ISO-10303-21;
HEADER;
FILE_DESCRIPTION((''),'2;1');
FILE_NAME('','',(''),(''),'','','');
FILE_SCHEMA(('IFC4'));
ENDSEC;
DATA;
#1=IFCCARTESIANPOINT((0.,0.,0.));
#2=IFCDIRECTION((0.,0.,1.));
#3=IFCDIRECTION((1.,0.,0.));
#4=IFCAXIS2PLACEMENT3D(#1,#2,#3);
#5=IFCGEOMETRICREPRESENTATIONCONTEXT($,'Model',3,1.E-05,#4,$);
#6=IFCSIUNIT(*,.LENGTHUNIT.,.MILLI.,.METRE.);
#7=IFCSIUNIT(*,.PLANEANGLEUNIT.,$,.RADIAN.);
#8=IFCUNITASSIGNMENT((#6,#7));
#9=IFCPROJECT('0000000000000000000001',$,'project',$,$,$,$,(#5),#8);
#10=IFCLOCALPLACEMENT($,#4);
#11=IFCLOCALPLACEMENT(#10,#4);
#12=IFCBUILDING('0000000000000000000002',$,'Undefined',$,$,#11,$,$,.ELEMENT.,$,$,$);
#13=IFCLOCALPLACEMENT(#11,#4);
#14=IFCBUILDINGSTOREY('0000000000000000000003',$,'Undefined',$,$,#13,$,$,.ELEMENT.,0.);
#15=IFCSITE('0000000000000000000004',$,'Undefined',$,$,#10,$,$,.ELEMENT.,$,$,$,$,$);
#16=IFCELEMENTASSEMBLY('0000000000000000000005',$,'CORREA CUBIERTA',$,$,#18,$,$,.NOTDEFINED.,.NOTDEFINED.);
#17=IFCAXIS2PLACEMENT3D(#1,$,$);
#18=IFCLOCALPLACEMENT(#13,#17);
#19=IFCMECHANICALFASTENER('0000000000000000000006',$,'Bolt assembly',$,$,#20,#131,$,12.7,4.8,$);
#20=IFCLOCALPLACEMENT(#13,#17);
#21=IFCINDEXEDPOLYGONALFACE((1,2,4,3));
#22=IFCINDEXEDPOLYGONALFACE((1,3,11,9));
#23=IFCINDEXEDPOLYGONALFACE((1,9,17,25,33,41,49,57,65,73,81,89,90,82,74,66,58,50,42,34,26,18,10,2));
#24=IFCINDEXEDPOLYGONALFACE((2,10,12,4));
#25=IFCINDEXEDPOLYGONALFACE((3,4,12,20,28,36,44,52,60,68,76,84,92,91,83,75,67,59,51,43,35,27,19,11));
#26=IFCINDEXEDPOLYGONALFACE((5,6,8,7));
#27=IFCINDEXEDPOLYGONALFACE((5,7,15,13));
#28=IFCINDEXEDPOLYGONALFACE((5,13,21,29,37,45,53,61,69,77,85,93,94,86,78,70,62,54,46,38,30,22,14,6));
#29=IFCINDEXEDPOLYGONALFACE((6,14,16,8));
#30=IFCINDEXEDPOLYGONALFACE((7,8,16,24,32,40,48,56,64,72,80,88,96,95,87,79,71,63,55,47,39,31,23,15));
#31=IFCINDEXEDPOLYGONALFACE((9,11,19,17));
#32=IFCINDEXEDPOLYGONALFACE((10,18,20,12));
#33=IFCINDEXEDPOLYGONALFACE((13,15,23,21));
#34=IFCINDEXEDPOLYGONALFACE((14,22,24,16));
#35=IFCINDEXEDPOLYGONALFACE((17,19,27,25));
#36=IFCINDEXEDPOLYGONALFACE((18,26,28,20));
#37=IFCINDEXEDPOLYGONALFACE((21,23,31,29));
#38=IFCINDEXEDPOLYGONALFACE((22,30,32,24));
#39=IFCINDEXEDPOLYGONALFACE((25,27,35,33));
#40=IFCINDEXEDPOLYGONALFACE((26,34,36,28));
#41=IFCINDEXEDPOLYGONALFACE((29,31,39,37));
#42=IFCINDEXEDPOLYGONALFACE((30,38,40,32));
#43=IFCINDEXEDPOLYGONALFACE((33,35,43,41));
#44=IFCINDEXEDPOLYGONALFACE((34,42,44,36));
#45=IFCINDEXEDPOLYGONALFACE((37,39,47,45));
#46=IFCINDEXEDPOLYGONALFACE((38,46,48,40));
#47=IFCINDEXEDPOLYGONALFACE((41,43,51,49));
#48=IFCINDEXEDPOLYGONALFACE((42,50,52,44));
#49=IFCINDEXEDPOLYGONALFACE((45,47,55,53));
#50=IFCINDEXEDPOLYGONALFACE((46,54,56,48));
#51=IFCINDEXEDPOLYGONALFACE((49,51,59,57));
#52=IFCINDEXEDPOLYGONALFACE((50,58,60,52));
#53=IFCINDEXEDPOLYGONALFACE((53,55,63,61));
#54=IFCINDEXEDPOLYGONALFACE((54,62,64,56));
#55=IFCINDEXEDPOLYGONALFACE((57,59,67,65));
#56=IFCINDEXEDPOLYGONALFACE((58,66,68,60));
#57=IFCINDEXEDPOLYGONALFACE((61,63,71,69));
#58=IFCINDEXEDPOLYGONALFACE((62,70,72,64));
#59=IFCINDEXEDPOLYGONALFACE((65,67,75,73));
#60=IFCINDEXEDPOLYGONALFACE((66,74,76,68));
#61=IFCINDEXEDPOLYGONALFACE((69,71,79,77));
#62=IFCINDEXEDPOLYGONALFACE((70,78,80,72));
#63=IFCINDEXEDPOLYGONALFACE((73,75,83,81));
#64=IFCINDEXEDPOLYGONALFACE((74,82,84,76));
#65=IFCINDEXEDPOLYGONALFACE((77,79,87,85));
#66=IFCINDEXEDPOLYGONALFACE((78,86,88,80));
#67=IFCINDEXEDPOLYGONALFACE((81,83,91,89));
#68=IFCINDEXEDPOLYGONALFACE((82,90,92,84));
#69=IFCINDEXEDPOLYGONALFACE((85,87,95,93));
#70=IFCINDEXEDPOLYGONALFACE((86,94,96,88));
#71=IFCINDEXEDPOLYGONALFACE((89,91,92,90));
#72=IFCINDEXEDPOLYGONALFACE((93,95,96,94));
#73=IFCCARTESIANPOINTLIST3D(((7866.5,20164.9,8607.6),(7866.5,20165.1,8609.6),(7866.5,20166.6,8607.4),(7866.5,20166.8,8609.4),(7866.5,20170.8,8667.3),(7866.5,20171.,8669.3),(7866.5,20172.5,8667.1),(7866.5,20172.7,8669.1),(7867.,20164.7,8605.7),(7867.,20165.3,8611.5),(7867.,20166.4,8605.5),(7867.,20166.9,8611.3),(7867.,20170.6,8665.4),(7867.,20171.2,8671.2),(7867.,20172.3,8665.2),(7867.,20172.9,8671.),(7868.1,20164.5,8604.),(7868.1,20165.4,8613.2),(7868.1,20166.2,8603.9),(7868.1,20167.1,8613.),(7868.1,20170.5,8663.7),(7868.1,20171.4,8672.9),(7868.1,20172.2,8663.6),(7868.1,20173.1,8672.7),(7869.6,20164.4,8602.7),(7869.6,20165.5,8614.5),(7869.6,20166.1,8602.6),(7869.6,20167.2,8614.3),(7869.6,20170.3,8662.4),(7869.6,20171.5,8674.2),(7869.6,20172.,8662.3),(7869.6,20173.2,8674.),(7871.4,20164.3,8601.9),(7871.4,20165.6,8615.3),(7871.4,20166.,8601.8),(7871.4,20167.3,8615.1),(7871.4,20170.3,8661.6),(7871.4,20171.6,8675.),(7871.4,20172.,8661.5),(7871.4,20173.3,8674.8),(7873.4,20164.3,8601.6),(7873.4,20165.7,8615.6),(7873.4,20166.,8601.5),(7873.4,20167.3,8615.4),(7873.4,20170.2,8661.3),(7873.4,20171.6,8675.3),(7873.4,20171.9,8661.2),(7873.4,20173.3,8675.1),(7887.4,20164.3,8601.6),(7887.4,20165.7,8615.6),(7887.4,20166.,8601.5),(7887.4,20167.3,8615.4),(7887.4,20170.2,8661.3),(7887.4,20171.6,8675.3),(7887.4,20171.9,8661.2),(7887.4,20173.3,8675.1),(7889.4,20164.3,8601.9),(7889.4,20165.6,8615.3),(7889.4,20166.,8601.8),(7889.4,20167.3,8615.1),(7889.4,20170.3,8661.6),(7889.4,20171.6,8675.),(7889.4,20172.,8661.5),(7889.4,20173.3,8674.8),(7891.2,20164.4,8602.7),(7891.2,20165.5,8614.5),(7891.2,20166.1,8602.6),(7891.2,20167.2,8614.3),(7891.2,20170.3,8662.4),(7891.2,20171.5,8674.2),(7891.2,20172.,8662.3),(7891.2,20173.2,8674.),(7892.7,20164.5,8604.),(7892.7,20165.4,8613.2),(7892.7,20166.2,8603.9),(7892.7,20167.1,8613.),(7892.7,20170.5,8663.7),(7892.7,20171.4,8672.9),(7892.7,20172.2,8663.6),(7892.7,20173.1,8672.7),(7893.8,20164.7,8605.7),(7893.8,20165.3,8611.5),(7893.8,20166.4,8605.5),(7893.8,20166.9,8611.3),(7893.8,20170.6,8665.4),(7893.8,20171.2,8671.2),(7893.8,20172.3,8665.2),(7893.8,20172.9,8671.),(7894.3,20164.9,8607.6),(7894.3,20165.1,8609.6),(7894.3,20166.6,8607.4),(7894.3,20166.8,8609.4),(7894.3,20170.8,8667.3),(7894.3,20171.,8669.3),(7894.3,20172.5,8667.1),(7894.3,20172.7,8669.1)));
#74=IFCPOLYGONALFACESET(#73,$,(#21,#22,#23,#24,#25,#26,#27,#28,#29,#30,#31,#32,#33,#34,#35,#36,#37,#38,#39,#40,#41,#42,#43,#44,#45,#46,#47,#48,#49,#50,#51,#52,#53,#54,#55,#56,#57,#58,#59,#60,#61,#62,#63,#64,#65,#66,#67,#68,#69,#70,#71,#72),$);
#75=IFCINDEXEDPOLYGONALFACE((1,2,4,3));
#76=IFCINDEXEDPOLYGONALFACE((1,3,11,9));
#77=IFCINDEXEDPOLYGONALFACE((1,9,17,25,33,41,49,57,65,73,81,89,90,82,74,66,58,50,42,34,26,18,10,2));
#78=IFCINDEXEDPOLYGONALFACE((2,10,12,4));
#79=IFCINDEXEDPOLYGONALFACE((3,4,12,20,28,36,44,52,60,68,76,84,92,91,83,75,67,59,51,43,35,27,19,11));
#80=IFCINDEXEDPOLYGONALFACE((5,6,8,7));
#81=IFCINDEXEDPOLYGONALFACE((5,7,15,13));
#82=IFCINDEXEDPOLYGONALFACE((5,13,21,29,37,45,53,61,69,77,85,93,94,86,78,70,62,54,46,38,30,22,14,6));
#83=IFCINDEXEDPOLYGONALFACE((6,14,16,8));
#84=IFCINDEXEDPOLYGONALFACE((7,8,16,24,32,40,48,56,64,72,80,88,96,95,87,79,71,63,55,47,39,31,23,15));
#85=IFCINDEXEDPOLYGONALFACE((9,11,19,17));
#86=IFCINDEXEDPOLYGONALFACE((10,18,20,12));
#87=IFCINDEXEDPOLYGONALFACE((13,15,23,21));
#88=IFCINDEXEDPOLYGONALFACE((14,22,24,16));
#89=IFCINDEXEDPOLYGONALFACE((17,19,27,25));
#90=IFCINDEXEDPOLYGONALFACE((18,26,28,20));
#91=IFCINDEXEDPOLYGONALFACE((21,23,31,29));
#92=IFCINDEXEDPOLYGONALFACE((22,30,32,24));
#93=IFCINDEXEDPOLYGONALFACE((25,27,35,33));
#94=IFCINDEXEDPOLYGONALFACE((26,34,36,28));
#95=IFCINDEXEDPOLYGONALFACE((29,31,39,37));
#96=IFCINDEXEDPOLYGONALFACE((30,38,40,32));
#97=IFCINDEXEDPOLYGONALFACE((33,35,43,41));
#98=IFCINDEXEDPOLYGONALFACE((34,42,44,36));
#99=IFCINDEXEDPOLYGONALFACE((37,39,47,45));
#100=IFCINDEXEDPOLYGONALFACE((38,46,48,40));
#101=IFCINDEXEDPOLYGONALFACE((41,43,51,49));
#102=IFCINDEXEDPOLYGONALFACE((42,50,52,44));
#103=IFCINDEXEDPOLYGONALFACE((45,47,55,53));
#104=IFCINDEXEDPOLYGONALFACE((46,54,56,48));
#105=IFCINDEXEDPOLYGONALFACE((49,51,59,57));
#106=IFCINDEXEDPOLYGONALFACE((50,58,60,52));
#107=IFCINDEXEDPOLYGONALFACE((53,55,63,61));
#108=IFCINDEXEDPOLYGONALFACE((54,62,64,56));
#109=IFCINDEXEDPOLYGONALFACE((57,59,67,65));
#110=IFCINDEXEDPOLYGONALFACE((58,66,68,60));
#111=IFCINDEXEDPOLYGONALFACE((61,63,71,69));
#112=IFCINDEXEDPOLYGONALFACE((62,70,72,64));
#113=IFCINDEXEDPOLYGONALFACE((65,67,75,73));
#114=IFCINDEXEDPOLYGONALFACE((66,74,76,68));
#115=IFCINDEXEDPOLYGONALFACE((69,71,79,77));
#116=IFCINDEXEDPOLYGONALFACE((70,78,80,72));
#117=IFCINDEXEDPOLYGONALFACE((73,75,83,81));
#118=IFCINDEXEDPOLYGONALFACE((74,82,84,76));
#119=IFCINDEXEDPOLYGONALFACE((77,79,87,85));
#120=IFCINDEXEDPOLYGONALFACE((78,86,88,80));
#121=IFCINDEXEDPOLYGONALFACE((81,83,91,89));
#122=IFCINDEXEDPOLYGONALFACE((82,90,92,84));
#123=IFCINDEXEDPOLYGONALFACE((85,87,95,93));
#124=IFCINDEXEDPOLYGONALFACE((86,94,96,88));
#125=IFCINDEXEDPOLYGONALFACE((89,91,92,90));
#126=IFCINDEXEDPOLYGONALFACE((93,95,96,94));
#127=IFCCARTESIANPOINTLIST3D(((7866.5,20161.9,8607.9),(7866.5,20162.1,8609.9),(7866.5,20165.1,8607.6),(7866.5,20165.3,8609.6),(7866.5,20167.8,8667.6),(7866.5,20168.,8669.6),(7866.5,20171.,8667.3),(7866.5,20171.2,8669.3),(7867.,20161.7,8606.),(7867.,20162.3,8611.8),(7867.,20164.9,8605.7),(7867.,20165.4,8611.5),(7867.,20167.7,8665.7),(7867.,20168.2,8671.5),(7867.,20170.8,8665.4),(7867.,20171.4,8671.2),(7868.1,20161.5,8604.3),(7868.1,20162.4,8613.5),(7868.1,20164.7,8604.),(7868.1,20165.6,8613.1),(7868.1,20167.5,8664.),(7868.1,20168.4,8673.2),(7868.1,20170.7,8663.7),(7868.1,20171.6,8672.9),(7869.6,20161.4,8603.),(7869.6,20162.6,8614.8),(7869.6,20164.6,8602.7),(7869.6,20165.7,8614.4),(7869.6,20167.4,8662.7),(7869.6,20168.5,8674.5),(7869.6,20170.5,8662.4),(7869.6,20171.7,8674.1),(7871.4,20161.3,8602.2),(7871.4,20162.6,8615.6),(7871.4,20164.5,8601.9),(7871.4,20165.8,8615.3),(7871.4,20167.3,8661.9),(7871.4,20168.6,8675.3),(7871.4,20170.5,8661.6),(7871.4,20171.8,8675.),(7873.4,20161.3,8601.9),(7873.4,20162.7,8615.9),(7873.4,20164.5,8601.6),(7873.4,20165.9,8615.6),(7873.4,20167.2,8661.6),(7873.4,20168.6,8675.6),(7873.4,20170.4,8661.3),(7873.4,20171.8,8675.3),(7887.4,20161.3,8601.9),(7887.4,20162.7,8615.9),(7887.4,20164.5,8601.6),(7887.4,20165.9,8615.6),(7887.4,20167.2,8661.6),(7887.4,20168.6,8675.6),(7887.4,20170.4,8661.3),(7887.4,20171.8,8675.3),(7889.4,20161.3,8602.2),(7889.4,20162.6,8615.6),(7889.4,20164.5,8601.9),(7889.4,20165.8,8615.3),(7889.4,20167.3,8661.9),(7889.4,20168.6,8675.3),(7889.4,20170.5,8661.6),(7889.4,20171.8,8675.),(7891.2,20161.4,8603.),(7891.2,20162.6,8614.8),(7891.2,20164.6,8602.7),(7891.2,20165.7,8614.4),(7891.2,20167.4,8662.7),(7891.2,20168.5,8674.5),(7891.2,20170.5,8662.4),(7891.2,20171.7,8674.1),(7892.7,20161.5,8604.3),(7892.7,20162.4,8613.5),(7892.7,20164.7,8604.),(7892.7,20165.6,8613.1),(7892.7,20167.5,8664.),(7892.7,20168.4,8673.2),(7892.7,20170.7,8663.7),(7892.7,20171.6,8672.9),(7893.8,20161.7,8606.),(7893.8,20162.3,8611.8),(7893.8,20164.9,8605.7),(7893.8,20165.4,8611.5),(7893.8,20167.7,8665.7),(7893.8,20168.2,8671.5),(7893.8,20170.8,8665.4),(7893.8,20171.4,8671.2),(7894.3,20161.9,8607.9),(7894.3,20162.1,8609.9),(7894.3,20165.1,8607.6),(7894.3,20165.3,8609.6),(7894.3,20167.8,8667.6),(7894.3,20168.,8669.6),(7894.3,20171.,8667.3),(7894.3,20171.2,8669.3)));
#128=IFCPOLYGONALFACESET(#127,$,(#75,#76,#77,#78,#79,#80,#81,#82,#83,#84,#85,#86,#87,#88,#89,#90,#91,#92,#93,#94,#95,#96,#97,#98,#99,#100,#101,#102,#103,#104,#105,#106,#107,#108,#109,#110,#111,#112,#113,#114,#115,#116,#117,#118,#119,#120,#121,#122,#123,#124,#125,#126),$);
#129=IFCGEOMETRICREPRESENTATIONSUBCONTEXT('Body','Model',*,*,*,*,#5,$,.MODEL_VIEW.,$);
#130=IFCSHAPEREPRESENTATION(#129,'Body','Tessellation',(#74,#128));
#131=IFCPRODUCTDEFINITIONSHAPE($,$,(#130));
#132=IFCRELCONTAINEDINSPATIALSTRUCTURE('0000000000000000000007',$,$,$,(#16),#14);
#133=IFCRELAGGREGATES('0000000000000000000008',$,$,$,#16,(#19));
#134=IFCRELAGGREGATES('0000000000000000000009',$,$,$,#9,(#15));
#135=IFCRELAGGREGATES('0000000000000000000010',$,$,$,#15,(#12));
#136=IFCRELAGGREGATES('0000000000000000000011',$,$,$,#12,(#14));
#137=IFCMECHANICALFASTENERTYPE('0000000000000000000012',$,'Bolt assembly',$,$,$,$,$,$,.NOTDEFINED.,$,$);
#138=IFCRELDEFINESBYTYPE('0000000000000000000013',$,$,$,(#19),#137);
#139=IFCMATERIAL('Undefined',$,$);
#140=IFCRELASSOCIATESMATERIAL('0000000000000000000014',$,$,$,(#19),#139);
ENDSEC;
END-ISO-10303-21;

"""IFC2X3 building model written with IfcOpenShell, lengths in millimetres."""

from ifc_helpers import new_model, entity, si_unit, frame, origin_with_axes, place, context, subcontext, project, spatial, source, transform, mapped, material, type_object, element, aggregate, save


model = new_model("IFC2X3")

# Units and contexts
model_context = context("Model", 3, precision=1e-05, world=origin_with_axes())
body_context = subcontext(model_context, "Body", "Model", "MODEL_VIEW")
ifc_project = project(units=[si_unit("LENGTHUNIT", "METRE", prefix="MILLI"), si_unit("PLANEANGLEUNIT", "RADIAN")], contexts=[model_context])

# Site, building, storey
site_placement = place(None, origin_with_axes())
site = spatial("IfcSite", under=ifc_project, at=site_placement, Name="Undefined", CompositionType="ELEMENT")
building_placement = place(site_placement, origin_with_axes())
building = spatial("IfcBuilding", under=site, at=building_placement, Name="Undefined", CompositionType="ELEMENT")
storey_placement = place(building_placement, origin_with_axes())
storey = spatial("IfcBuildingStorey", under=building, at=storey_placement, Name="Undefined", CompositionType="ELEMENT", Elevation=0.0)

# Element assembly, mechanical fastener
ifc_material_1 = material(Name="Undefined")
mechanical_fastener_type = type_object("IfcMechanicalFastenerType", Name="Bolt assembly")
shared_circle_1 = entity("IfcCircle", entity("IfcAxis2Placement2D", entity("IfcCartesianPoint", [0.0, -7.0]), entity("IfcDirection", [1.0, 0.0])), 7.0)
shared_circle_2 = entity("IfcCircle", entity("IfcAxis2Placement2D", entity("IfcCartesianPoint", [0.0, 7.0]), entity("IfcDirection", [-1.0, 0.0])), 7.0)
shared_composite_curve = entity("IfcCompositeCurve", [entity("IfcCompositeCurveSegment", "CONTINUOUS", True, entity("IfcPolyline", [entity("IfcCartesianPoint", [7.0, 7.0]), entity("IfcCartesianPoint", [7.0, -7.0])])), entity("IfcCompositeCurveSegment", "CONTINUOUS", True, entity("IfcTrimmedCurve", shared_circle_1, [entity("IfcParameterValue", 0.0)], [entity("IfcParameterValue", 3.141593)], False, "PARAMETER")), entity("IfcCompositeCurveSegment", "CONTINUOUS", True, entity("IfcPolyline", [entity("IfcCartesianPoint", [-7.0, -7.0]), entity("IfcCartesianPoint", [-7.0, 7.0])])), entity("IfcCompositeCurveSegment", "DISCONTINUOUS", True, entity("IfcTrimmedCurve", shared_circle_2, [entity("IfcParameterValue", 0.0)], [entity("IfcParameterValue", 3.141593)], False, "PARAMETER"))], False)
assembly_1_placement = place(storey_placement, origin_with_axes())
assembly_1 = element("IfcElementAssembly", 1, at=assembly_1_placement, inside=storey, Name="CORREA CUBIERTA", AssemblyPlace="NOTDEFINED", PredefinedType="NOTDEFINED")
shared_shape_1 = source(origin_with_axes(), body_context, "Body", "SweptSolid", [
    entity("IfcExtrudedAreaSolid", entity("IfcArbitraryClosedProfileDef", "AREA", None, shared_composite_curve), entity("IfcAxis2Placement3D", entity("IfcCartesianPoint", [0.0, 3.1, 0.0]), entity("IfcDirection", [0.0, 1.0, 0.0]), entity("IfcDirection", [1.0, 0.0, 0.0])), entity("IfcDirection", [0.0, 0.0, 1.0]), 1.7),
    entity("IfcExtrudedAreaSolid", entity("IfcArbitraryClosedProfileDef", "AREA", None, shared_composite_curve), entity("IfcAxis2Placement3D", entity("IfcCartesianPoint", [0.0, 0.1, 0.0]), entity("IfcDirection", [0.0, 1.0, 0.0]), entity("IfcDirection", [1.0, 0.0, 0.0])), entity("IfcDirection", [0.0, 0.0, 1.0]), 3.2),
])
mechanical_fastener_1_placement = place(assembly_1_placement, frame((7880.4, 20167.8, 8668.6), z_axis=(1.0, 0.0, 0.0), x_axis=(0.0, -0.099503, -0.995037)))
mechanical_fastener_1 = element("IfcMechanicalFastener", 2, at=mechanical_fastener_1_placement, type_object=mechanical_fastener_type, material=ifc_material_1, Name="Bolt assembly", NominalDiameter=12.7, NominalLength=4.8, context=body_context, shape_type="MappedRepresentation", body=[
    mapped(shared_shape_1, transform((0.0, 0.0, 0.0))),
    mapped(shared_shape_1, transform((60.0, 0.0, 0.0))),
])

aggregate(assembly_1, [mechanical_fastener_1])

save(model, "model.ifc")
